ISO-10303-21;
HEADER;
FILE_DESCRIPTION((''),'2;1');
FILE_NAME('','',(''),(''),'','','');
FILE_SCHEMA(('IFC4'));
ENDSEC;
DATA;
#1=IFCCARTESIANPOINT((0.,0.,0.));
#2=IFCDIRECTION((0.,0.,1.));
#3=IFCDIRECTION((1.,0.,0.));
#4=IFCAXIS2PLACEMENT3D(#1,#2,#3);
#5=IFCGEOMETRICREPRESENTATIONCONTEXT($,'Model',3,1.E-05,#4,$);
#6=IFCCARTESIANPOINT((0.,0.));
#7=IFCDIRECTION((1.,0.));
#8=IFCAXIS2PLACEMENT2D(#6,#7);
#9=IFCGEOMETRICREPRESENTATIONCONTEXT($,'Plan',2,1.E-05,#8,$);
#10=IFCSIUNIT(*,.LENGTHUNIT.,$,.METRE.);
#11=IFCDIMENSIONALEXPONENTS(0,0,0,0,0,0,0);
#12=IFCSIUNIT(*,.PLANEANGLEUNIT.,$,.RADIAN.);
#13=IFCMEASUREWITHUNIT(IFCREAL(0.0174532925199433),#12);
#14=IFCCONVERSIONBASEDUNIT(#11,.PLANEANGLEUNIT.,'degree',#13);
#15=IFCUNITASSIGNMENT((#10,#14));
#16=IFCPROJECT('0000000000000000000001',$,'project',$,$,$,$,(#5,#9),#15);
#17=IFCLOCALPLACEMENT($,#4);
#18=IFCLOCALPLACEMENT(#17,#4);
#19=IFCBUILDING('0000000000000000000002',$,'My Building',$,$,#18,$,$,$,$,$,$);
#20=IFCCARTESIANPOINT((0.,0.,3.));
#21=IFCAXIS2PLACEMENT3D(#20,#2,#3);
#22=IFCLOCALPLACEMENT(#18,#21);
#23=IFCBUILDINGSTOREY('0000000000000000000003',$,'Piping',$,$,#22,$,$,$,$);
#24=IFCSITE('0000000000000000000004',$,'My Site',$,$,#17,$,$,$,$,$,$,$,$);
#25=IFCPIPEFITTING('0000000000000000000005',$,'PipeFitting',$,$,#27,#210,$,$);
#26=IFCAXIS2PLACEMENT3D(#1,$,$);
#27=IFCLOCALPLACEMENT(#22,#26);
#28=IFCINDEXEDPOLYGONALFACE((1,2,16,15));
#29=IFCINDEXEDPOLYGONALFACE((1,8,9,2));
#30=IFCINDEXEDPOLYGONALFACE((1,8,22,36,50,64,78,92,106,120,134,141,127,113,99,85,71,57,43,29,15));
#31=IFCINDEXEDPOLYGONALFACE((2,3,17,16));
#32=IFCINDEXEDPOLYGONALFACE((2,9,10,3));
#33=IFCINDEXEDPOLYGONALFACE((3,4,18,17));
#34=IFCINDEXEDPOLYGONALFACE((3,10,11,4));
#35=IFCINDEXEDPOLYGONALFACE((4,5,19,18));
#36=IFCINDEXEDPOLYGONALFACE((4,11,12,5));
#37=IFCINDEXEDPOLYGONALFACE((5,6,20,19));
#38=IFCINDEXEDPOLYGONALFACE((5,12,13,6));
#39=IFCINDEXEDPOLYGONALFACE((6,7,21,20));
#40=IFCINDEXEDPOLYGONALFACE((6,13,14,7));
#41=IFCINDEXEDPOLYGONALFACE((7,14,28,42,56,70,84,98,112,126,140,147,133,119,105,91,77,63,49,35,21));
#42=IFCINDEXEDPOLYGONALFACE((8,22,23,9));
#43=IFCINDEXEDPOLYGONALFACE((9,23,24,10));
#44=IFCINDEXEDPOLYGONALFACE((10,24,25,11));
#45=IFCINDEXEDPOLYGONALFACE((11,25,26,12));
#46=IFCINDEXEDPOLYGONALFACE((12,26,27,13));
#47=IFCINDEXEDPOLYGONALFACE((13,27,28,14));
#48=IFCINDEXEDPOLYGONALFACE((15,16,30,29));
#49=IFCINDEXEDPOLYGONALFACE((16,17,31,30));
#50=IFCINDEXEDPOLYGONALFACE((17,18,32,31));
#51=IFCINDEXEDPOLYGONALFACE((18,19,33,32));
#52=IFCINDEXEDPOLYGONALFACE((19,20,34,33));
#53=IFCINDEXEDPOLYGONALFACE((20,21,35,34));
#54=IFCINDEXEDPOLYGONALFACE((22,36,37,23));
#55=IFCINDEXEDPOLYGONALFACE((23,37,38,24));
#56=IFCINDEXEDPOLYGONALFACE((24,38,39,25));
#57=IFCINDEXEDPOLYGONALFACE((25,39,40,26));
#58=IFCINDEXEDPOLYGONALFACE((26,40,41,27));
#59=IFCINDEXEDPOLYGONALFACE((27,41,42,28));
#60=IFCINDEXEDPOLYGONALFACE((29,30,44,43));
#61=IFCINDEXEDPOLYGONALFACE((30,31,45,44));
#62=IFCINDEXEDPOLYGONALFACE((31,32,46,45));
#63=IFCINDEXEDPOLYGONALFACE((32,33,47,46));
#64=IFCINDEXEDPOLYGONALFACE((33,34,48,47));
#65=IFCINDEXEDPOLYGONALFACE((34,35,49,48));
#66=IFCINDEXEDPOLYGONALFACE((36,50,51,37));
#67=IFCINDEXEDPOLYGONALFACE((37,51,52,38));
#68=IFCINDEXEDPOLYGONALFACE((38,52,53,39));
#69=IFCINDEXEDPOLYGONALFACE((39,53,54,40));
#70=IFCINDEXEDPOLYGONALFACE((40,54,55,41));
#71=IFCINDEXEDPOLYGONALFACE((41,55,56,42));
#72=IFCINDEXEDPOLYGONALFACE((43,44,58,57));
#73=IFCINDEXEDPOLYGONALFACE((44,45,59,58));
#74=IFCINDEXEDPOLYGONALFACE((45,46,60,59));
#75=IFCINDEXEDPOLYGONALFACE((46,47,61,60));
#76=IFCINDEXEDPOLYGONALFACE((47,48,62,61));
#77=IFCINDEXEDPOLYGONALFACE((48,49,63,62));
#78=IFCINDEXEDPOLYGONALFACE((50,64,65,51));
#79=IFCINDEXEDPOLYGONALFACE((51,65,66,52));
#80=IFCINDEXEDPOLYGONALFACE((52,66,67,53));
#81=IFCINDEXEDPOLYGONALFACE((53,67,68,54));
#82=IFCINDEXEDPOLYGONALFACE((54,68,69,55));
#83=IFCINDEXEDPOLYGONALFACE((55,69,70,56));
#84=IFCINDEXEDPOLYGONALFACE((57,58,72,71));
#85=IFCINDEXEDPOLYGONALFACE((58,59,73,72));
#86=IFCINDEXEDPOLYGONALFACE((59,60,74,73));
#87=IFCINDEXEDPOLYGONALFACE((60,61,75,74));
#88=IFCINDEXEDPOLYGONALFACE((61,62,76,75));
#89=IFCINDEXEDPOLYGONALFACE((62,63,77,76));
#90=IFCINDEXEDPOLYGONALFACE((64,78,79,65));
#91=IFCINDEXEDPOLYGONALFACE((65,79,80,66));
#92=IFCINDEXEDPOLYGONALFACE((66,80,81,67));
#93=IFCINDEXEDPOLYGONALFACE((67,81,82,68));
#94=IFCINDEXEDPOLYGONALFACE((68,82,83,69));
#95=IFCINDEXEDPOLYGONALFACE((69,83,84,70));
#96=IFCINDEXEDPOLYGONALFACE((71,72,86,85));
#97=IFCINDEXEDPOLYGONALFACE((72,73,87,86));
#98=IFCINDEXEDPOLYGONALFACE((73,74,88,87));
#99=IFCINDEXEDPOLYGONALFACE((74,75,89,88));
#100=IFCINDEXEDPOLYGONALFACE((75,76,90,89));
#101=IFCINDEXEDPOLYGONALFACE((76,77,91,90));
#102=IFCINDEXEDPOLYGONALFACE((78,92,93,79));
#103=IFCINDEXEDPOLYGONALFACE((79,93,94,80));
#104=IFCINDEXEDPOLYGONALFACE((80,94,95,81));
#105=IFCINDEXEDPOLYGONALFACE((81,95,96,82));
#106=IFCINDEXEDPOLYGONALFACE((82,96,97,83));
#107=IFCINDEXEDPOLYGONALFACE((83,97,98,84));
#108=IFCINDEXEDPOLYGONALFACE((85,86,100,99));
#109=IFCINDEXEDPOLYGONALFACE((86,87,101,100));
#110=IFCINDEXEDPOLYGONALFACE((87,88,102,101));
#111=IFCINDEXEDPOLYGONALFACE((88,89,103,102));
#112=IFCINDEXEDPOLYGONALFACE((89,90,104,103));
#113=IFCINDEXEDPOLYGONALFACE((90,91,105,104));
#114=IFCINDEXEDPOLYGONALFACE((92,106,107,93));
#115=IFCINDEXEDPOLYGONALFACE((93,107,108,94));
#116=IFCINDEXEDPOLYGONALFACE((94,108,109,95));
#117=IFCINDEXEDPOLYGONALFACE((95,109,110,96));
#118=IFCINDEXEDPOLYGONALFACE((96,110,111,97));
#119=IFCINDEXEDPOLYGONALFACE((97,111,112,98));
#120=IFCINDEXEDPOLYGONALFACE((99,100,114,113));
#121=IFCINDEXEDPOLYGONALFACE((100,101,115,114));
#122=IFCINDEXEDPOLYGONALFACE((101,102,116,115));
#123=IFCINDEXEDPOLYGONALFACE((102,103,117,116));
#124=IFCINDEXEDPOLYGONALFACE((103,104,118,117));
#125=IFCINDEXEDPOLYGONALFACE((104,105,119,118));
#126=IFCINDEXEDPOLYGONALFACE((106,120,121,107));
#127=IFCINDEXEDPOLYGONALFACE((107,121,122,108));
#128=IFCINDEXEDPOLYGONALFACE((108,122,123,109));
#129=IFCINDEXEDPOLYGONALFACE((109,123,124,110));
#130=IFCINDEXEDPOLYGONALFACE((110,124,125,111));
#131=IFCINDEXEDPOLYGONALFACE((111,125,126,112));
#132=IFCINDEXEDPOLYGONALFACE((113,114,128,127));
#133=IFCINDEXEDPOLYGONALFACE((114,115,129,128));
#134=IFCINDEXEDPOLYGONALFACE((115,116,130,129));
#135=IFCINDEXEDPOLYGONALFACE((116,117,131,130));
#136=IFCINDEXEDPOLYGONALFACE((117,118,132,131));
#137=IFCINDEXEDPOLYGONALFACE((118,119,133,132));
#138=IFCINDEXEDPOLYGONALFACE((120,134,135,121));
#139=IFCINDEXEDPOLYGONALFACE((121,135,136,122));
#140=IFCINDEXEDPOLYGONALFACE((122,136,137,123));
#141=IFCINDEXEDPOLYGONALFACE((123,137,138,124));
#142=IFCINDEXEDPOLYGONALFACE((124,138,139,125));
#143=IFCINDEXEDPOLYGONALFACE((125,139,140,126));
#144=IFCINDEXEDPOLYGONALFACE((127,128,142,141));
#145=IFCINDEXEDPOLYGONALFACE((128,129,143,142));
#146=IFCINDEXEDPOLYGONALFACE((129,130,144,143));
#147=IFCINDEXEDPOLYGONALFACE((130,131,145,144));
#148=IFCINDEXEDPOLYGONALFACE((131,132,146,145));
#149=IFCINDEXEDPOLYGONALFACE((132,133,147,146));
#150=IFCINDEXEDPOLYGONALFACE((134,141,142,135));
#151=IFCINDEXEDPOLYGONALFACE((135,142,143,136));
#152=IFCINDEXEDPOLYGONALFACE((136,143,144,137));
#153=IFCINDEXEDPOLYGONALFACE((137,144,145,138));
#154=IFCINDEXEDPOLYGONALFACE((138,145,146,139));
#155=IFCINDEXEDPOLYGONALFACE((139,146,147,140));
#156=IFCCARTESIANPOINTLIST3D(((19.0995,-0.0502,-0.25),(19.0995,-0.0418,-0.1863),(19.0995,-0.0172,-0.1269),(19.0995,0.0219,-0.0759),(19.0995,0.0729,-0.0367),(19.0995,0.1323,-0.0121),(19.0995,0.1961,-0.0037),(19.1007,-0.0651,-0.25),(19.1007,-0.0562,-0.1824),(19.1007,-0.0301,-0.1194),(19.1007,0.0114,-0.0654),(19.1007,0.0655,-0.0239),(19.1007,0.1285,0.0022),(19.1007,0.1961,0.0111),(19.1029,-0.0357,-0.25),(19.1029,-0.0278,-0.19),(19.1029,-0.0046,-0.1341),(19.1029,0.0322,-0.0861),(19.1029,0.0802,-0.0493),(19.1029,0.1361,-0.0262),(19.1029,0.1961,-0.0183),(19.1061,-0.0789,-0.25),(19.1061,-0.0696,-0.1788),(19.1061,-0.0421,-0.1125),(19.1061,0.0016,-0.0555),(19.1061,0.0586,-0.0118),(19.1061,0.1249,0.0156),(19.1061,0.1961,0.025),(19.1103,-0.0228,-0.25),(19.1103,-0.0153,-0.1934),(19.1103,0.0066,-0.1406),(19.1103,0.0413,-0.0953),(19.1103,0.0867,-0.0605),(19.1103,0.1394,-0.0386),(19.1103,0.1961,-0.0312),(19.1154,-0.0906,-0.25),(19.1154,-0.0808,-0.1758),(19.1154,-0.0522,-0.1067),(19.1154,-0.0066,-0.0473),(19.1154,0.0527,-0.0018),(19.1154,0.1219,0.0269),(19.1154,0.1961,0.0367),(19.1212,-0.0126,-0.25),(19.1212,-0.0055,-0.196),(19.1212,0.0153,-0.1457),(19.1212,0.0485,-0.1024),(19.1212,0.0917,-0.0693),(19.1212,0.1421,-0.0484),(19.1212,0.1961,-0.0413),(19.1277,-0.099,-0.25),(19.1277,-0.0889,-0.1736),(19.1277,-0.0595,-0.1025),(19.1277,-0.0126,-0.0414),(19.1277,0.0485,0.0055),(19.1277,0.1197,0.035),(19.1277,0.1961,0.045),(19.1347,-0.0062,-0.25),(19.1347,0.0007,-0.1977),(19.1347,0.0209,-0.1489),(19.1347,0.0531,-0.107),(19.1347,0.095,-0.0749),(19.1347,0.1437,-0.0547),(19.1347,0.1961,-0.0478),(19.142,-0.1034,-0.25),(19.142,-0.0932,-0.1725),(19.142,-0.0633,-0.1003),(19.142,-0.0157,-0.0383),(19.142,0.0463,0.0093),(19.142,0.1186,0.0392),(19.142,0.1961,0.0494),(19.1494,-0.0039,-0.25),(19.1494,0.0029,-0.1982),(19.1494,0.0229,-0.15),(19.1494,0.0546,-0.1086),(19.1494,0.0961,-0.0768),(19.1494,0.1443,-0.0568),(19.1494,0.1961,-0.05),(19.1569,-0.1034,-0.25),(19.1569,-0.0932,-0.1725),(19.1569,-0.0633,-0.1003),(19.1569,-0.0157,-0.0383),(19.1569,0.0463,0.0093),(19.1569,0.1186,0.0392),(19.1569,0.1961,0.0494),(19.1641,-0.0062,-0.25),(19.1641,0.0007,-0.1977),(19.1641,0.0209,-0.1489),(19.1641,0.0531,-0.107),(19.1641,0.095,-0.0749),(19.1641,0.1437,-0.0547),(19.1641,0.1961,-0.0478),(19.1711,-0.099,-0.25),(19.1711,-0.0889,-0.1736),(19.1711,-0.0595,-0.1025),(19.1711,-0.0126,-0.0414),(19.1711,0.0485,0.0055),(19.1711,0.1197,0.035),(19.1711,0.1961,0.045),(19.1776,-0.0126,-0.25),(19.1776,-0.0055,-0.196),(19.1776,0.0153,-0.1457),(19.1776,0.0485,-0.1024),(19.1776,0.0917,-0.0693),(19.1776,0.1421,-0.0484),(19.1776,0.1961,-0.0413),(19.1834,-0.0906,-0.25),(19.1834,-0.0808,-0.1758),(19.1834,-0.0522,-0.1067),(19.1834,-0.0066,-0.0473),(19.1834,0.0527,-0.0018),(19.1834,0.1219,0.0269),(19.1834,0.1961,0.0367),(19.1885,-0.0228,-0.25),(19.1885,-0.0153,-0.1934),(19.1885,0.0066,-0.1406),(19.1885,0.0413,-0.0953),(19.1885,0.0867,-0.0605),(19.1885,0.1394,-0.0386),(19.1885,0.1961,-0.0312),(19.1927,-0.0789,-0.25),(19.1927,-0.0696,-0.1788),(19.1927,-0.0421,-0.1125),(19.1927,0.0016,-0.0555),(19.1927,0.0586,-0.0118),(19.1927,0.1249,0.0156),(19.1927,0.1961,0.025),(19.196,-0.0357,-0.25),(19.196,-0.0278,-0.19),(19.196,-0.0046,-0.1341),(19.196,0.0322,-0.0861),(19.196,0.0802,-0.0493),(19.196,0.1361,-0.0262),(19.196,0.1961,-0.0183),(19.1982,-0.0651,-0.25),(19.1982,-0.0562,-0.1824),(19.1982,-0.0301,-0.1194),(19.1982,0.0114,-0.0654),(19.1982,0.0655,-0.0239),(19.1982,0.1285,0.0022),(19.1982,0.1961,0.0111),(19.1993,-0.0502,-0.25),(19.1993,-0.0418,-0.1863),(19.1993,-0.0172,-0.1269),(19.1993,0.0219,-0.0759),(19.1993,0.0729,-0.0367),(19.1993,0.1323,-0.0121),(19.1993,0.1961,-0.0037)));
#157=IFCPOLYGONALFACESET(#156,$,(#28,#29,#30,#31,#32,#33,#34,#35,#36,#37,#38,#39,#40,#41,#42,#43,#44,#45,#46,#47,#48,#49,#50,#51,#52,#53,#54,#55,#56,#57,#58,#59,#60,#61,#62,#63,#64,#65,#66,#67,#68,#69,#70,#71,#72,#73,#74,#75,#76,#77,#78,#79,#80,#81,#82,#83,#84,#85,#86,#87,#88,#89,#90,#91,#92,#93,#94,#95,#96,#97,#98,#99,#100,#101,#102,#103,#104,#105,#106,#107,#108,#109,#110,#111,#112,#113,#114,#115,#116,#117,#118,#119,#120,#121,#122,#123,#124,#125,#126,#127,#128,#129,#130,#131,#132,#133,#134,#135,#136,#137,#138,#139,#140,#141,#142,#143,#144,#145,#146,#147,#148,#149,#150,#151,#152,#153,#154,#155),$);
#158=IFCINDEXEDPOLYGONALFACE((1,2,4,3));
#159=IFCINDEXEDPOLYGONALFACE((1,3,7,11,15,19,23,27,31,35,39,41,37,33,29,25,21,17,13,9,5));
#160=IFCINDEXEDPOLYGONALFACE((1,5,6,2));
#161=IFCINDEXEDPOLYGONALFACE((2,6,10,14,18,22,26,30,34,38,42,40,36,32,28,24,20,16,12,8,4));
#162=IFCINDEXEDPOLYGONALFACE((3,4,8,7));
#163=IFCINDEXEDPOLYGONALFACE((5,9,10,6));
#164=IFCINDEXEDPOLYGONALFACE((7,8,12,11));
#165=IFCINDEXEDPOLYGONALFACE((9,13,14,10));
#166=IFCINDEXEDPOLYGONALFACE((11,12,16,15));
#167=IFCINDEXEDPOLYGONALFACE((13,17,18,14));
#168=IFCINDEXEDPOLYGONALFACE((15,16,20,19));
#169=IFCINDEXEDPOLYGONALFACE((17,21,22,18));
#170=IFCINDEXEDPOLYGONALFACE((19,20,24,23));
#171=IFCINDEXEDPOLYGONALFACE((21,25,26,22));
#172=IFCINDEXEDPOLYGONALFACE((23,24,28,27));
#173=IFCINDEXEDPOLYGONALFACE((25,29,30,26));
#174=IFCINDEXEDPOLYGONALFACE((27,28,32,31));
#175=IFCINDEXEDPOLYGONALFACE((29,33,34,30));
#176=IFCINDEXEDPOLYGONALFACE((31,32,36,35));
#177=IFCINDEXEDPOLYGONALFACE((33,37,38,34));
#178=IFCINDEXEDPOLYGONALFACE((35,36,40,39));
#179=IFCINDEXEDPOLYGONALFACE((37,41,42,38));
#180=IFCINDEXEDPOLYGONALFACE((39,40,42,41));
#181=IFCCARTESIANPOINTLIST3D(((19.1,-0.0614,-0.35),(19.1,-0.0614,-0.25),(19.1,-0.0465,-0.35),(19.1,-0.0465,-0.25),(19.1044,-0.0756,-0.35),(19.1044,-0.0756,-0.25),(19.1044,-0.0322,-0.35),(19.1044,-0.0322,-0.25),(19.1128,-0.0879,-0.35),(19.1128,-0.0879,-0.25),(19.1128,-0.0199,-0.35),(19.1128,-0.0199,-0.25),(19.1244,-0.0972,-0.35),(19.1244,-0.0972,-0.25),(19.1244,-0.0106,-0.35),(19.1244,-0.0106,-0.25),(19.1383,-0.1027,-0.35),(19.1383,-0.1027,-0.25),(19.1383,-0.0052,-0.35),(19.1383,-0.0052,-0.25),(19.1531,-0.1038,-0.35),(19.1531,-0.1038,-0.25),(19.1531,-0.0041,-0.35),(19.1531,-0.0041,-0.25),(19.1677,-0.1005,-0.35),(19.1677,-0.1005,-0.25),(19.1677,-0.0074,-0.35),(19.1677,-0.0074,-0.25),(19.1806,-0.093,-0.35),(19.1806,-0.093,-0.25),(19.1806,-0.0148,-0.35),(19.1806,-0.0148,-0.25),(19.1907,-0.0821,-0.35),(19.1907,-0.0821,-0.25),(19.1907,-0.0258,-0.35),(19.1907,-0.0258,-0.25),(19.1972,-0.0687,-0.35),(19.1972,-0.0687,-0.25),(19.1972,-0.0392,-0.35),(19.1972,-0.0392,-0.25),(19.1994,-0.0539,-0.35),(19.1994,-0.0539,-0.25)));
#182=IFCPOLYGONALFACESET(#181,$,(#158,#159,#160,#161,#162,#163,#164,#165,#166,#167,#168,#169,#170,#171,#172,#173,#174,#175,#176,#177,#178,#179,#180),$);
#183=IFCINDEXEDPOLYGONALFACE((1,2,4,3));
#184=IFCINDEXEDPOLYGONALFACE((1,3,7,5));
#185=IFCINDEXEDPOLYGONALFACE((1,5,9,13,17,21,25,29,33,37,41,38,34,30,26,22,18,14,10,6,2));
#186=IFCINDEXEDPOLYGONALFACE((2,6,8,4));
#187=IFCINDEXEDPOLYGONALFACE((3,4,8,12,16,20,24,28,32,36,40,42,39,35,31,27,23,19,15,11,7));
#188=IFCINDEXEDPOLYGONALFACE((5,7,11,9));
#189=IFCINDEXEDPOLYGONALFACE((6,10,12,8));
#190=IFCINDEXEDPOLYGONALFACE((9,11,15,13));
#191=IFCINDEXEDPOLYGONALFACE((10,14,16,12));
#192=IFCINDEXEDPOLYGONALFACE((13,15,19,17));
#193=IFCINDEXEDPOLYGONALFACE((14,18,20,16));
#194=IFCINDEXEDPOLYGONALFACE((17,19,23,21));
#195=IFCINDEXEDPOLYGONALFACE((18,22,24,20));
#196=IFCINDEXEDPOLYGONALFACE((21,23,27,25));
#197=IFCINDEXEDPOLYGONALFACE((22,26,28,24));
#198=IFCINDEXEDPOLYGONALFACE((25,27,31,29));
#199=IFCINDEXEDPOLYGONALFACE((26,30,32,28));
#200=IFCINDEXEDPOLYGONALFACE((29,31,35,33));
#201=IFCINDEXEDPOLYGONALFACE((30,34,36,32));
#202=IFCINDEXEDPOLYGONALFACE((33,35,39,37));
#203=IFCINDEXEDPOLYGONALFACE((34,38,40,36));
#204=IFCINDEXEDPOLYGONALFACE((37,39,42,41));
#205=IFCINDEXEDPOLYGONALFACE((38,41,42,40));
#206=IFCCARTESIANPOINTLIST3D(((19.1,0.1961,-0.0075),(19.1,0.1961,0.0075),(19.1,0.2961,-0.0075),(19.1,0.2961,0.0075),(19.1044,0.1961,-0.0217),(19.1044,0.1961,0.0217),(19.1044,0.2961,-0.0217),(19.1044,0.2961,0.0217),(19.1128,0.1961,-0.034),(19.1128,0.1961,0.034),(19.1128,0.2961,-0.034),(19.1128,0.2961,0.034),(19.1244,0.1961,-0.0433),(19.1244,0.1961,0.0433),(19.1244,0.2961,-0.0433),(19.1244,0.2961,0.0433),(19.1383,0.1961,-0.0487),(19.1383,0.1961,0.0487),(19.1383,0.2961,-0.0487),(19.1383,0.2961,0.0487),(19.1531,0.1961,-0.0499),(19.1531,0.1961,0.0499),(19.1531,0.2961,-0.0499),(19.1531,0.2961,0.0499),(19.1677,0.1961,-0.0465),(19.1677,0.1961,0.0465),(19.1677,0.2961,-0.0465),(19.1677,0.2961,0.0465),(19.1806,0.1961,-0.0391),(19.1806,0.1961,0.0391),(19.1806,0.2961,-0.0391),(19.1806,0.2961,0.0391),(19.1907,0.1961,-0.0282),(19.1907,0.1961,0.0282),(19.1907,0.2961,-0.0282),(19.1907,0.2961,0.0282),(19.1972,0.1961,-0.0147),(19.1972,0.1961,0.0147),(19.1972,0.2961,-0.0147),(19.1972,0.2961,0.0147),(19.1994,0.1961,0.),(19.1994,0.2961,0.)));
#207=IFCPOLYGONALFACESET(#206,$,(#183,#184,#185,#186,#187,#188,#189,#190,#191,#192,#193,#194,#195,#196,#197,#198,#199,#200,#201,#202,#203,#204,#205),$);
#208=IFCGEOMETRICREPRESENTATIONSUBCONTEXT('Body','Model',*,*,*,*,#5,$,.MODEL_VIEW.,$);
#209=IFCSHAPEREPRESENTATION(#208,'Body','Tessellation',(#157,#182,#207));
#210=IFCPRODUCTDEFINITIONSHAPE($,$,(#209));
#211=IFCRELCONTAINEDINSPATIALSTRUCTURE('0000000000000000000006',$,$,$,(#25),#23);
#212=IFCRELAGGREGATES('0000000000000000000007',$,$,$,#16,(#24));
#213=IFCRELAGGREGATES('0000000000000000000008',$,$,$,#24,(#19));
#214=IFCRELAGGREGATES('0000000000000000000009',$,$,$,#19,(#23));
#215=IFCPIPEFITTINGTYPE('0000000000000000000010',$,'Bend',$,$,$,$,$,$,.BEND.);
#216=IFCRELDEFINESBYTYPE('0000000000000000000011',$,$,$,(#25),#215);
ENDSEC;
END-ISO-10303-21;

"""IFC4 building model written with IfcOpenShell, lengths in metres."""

from ifc_helpers import new_model, entity, si_unit, converted_unit, frame, origin_with_axes, origin_2d_with_axis, place, context, subcontext, project, spatial, circle, extrude, source, transform, mapped, type_object, type_shapes, element, save


model = new_model("IFC4")

# Units and contexts
model_context = context("Model", 3, precision=1e-05, world=origin_with_axes())
plan_context = context("Plan", 2, precision=1e-05, world=origin_2d_with_axis())
body_context = subcontext(model_context, "Body", "Model", "MODEL_VIEW")
ifc_project = project(units=[si_unit("LENGTHUNIT", "METRE"), converted_unit("PLANEANGLEUNIT", "degree", entity("IfcReal", 0.0174532925199433), si_unit("PLANEANGLEUNIT", "RADIAN"), dimensions=[0, 0, 0, 0, 0, 0, 0])], contexts=[model_context, plan_context])

# Site, building, storey
site_placement = place(None, origin_with_axes())
site = spatial("IfcSite", under=ifc_project, at=site_placement, Name="My Site")
building_placement = place(site_placement, origin_with_axes())
building = spatial("IfcBuilding", under=site, at=building_placement, Name="My Building")
storey_placement = place(building_placement, frame((0.0, 0.0, 3.0), z_axis=(0.0, 0.0, 1.0), x_axis=(1.0, 0.0, 0.0)))
storey = spatial("IfcBuildingStorey", under=building, at=storey_placement, Name="Piping")

# Pipe fitting
pipe_fitting_type = type_object("IfcPipeFittingType", Name="Bend", PredefinedType="BEND")
shared_shape = source(origin_with_axes(), body_context, "Body", "SolidModel", [
    entity("IfcSweptDiskSolid", entity("IfcIndexedPolyCurve", entity("IfcCartesianPointList3D", [[0.0, 0.0, -0.1], [0.0, -0.0732, -0.2768], [0.0, -0.25, -0.35]]), [entity("IfcArcIndex", [1, 2, 3])]), 0.05),
    extrude(circle(Radius=0.05), origin_with_axes(), (0.0, 0.0, -1.0), 0.1),
    extrude(circle(Radius=0.05), frame((0.0, -0.25, -0.35), z_axis=(0.0, -1.0, 0.0), x_axis=(1.0, 0.0, 0.0)), (0.0, 0.0, 1.0), 0.1),
])
type_shapes(pipe_fitting_type, [shared_shape])
for number, where, z_axis, x_axis, name in (
    (1, (19.1494, -0.0539, -0.35), (0.0, 0.0, -1.0), (1.0, 0.0, 0.0), "PipeFitting"),
):
    element("IfcPipeFitting", number, at=place(storey_placement, frame(where, z_axis=z_axis, x_axis=x_axis)), inside=storey, type_object=pipe_fitting_type, Name=name, context=body_context, shape_type="MappedRepresentation", body=[
        mapped(shared_shape, transform((0.0, 0.0, 0.0), x_axis=(1.0, 0.0, 0.0), y_axis=(0.0, 1.0, 0.0), z_axis=(0.0, 0.0, 1.0), scale=1.0)),
    ])

save(model, "model.ifc")
